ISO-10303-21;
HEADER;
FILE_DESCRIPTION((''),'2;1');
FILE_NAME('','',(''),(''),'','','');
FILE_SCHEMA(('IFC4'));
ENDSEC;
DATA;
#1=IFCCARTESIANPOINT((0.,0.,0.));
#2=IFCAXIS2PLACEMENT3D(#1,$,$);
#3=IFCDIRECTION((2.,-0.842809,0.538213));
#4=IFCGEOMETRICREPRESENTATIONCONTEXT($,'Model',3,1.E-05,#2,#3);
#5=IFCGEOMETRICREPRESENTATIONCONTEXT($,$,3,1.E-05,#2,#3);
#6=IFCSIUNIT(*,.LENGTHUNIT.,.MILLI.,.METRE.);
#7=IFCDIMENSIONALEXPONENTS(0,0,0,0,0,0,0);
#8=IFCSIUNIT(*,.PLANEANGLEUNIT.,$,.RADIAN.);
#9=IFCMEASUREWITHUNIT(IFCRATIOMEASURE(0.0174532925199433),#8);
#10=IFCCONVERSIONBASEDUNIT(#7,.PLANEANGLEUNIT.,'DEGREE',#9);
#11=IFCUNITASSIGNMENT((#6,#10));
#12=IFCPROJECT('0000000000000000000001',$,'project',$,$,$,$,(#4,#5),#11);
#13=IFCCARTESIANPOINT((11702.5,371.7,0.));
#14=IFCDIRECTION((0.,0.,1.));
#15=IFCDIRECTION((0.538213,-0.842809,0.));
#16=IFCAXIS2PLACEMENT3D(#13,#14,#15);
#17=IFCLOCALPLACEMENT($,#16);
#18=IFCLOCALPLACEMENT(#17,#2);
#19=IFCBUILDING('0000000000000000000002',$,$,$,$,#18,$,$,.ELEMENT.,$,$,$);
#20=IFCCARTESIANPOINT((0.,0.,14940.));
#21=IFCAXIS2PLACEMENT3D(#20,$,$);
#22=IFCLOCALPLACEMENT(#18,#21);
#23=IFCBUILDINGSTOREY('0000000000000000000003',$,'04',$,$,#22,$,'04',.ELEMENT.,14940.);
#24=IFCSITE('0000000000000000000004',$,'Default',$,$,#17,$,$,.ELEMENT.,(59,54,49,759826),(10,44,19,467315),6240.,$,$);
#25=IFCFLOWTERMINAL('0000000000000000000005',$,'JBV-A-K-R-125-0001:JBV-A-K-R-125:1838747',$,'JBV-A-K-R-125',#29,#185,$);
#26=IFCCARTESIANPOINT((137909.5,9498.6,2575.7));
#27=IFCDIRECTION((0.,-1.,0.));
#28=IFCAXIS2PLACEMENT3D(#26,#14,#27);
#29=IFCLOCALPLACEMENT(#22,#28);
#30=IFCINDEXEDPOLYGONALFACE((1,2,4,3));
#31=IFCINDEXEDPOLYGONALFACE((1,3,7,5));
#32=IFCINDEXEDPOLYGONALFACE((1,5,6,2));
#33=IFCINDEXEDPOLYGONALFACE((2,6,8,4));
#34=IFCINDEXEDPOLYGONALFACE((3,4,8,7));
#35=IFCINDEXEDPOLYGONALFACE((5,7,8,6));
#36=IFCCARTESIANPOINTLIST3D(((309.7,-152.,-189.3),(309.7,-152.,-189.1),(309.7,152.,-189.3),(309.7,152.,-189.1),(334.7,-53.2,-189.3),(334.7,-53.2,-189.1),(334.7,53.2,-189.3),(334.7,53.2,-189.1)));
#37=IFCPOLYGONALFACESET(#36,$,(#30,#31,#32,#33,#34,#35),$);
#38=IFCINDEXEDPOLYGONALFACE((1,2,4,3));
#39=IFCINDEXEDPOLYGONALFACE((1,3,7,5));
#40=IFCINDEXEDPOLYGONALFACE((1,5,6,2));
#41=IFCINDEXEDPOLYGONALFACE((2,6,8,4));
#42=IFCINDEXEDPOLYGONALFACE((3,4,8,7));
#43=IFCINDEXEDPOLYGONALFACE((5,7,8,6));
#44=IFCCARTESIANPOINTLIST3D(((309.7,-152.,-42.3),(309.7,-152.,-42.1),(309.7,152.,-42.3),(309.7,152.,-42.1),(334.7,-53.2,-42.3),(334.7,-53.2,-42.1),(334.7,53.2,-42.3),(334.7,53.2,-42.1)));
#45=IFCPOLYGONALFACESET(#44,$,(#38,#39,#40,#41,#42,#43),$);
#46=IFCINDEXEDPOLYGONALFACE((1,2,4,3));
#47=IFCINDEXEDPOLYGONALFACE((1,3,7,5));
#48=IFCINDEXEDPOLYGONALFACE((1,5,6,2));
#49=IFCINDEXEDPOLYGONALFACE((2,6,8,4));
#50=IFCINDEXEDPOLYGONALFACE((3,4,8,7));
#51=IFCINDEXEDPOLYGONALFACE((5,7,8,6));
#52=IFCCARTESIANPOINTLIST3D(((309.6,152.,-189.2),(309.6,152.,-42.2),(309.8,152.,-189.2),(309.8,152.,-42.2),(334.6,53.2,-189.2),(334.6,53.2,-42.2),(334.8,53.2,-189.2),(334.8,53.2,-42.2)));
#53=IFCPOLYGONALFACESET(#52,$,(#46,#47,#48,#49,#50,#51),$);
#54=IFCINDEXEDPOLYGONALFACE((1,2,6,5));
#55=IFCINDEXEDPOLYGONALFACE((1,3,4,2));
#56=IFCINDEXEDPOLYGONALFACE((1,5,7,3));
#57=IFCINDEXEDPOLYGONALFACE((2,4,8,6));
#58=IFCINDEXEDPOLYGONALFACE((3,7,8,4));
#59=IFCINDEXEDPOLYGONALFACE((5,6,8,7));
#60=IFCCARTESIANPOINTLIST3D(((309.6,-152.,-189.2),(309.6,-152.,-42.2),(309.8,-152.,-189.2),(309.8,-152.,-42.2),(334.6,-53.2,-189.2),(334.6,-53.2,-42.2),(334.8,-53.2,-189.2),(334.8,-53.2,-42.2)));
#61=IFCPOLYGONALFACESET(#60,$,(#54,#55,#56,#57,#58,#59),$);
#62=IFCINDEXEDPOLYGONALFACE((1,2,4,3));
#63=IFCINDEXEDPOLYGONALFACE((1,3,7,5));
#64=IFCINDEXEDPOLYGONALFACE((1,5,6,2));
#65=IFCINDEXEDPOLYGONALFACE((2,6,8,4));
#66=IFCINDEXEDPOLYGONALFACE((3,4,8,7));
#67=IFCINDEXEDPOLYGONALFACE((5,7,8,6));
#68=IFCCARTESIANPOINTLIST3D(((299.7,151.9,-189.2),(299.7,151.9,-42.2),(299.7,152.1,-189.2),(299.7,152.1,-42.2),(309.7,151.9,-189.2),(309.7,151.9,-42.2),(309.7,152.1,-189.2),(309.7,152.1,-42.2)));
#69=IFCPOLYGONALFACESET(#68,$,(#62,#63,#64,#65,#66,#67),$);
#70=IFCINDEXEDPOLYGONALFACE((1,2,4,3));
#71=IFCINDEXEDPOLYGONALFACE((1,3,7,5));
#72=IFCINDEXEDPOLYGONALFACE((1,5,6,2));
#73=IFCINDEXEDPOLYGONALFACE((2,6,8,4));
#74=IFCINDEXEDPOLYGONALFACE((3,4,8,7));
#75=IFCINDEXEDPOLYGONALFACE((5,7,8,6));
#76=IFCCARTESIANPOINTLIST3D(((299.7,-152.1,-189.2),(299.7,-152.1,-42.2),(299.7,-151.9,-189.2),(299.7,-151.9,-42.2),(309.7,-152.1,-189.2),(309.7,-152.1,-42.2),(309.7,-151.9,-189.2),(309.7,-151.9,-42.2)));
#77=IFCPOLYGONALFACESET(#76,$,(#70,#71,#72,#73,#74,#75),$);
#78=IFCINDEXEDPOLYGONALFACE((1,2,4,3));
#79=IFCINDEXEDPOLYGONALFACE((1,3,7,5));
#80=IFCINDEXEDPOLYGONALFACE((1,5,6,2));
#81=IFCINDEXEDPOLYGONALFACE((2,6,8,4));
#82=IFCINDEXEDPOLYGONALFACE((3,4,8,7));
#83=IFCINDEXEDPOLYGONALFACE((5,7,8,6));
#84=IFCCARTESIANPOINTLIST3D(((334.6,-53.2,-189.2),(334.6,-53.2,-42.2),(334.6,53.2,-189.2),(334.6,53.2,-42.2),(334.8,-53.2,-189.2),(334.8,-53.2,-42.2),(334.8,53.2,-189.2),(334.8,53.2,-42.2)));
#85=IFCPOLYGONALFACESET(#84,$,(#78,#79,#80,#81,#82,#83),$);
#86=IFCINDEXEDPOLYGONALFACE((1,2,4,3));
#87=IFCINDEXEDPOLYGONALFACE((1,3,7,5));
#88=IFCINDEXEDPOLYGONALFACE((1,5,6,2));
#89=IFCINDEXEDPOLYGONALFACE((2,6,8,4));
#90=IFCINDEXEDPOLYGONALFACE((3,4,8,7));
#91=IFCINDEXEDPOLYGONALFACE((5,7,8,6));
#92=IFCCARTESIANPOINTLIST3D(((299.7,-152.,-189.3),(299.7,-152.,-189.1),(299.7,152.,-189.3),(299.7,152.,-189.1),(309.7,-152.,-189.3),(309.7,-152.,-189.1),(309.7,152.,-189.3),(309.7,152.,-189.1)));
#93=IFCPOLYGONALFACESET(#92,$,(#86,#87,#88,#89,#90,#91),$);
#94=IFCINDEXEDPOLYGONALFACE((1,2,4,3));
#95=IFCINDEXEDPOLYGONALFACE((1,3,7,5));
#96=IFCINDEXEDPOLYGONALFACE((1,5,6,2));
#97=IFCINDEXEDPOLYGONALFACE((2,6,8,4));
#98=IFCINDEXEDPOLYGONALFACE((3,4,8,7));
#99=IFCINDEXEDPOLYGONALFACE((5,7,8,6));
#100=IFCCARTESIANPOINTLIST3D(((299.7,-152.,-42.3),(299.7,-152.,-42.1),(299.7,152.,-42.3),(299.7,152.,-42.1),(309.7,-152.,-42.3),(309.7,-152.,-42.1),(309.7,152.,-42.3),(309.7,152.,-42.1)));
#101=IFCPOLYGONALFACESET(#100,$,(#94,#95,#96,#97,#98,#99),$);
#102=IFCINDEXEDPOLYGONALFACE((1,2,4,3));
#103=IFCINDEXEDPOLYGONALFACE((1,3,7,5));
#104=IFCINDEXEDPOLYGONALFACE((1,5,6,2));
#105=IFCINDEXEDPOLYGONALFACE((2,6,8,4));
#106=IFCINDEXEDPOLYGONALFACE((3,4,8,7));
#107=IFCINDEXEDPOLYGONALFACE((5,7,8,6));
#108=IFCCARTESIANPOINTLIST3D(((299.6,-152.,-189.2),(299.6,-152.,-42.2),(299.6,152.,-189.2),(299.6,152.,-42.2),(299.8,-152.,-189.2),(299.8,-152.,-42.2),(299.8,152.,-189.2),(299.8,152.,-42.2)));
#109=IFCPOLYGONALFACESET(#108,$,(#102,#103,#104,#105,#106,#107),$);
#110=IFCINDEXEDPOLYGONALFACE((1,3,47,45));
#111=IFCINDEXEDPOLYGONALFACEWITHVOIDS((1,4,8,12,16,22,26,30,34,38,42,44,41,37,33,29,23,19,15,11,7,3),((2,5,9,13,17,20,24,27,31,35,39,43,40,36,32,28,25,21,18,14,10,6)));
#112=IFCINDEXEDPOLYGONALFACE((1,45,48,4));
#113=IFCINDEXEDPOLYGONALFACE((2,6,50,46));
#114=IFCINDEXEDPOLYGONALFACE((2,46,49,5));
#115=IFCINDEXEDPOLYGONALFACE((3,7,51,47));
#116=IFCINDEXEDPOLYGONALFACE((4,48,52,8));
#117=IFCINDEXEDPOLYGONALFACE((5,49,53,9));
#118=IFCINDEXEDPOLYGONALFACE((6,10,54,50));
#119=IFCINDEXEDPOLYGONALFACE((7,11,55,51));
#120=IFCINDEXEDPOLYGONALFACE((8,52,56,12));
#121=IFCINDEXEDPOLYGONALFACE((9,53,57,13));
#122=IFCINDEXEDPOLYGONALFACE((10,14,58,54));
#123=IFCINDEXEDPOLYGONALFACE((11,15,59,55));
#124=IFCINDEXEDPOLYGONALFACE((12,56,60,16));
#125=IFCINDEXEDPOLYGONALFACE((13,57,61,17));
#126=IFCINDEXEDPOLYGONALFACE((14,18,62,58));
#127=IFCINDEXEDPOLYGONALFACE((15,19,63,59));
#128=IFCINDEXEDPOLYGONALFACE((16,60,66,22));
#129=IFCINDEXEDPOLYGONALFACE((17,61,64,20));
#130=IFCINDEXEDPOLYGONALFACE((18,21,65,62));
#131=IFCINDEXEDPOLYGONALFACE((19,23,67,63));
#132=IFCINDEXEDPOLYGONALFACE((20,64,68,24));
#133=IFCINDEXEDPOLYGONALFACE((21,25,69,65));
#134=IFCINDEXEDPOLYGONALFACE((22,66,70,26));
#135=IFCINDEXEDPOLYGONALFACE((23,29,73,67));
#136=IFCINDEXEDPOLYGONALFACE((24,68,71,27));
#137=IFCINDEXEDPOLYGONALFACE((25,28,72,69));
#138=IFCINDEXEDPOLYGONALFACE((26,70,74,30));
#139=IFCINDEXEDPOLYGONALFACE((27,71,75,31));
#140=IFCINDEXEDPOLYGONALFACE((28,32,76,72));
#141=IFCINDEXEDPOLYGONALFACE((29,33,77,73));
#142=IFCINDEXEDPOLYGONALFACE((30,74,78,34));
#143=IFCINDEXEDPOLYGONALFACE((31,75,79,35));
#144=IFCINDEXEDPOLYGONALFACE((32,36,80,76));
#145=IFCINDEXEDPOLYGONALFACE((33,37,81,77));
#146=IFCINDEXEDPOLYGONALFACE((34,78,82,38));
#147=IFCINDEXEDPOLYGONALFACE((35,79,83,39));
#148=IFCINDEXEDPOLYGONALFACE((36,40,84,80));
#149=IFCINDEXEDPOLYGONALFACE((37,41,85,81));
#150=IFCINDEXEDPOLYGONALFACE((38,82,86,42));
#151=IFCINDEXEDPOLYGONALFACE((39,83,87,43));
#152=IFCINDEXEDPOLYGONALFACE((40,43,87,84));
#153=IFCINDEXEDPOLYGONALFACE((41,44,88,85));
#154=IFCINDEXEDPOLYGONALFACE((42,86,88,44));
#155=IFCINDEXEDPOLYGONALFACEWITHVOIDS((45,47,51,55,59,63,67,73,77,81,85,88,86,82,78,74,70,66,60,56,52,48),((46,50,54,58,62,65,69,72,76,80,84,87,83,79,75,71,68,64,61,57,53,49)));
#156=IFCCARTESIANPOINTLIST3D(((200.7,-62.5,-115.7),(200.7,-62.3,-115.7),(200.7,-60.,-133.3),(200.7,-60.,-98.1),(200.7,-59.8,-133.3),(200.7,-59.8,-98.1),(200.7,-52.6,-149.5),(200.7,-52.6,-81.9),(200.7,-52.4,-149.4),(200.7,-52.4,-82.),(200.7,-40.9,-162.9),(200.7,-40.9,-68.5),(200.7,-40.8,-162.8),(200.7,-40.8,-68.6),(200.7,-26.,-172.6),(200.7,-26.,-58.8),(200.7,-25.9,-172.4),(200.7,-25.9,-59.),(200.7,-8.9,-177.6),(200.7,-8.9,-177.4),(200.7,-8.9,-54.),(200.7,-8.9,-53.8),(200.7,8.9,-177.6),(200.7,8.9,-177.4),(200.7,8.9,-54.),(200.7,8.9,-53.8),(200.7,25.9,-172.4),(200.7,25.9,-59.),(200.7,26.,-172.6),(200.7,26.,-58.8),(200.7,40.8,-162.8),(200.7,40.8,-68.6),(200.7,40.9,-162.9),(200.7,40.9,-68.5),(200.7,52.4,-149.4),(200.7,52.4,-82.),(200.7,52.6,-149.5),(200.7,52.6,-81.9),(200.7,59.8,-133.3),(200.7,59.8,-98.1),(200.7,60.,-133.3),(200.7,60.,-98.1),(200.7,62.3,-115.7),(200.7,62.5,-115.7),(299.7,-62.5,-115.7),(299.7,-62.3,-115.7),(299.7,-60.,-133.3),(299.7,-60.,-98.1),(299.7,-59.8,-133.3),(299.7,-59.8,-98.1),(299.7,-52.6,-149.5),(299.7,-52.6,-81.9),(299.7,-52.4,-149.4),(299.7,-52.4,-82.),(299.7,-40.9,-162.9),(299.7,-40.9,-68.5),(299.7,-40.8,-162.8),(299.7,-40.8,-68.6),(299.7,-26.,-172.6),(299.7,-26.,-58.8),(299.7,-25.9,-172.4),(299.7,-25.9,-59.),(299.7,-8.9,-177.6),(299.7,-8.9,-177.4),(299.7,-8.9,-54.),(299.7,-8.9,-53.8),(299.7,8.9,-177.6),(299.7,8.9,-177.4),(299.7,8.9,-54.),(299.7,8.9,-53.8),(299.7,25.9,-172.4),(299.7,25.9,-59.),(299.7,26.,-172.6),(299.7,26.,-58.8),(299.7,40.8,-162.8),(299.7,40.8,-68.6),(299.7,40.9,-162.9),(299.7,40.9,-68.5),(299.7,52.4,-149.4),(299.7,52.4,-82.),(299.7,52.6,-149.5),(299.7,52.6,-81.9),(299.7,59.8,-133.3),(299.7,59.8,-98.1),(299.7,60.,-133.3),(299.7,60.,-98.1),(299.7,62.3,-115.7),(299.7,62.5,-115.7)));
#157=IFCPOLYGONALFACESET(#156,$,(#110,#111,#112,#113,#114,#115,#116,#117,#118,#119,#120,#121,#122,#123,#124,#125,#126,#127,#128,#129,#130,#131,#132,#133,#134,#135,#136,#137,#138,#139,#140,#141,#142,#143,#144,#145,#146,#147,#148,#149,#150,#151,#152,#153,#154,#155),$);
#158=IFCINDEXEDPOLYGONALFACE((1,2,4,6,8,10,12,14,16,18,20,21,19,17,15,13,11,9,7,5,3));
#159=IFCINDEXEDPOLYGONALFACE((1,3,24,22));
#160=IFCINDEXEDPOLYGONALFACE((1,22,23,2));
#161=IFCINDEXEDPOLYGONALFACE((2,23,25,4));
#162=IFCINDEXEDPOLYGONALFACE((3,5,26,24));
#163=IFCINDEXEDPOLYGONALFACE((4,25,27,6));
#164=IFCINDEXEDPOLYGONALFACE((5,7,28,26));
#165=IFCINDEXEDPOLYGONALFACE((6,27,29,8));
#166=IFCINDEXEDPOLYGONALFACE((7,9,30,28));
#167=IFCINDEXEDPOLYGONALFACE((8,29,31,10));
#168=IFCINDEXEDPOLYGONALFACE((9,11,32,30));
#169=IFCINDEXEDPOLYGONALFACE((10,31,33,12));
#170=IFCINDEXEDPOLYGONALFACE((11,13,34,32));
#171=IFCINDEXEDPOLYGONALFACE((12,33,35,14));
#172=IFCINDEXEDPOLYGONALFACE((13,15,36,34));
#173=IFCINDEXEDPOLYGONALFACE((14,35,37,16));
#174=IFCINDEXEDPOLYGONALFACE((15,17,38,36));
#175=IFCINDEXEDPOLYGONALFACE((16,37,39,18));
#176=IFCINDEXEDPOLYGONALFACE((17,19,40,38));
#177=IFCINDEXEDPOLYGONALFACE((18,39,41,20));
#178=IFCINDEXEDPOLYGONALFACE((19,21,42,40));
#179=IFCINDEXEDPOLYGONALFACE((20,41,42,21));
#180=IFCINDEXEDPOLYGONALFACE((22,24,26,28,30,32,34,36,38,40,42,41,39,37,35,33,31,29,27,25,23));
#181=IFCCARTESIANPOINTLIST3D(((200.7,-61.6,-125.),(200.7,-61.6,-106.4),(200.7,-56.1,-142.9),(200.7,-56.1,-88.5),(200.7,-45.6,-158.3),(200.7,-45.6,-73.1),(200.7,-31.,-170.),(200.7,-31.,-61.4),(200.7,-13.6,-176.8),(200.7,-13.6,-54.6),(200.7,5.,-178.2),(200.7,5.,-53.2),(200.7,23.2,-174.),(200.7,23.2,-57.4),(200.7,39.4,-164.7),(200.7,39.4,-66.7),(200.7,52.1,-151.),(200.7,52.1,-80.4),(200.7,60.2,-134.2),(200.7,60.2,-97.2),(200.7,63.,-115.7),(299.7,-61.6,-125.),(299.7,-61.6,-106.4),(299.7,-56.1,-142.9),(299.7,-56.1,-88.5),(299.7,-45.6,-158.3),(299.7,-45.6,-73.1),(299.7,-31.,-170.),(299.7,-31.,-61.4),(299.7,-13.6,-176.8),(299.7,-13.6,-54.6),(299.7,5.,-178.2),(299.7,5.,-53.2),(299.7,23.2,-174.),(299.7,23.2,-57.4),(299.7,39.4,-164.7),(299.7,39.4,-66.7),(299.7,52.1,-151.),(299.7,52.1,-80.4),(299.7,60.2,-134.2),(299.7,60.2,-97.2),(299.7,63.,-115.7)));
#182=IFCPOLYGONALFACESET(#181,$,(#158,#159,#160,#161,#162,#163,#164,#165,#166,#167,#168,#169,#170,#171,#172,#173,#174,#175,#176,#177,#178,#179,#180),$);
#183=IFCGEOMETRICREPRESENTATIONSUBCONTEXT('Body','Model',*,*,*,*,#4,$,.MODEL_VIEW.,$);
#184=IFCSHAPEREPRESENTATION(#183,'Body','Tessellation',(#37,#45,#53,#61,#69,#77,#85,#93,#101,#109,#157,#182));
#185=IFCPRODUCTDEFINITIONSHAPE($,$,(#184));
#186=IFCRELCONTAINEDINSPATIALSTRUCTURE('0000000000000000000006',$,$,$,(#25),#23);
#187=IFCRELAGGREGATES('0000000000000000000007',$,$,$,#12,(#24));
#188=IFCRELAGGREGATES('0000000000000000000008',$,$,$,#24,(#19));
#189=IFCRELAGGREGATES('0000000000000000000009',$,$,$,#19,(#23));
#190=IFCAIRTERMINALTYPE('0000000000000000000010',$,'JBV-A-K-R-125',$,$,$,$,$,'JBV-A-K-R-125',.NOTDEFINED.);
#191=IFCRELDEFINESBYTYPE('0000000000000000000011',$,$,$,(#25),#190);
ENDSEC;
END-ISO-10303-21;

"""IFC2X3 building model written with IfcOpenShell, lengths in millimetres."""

from ifc_helpers import new_model, entity, si_unit, converted_unit, direction, frame, frame_2d, origin, origin_2d_with_axis, place, context, subcontext, project, spatial, polyline, circle_curve, parameter, trimmed, segment, composite_curve, rectangle, circle, outline, extrude, source, transform, mapped, type_object, type_shapes, element, save


model = new_model("IFC2X3")

# Units and contexts
model_context = context("Model", 3, precision=1e-05, world=origin(), true_north=direction((2.0, -0.842809, 0.538213)))
context_of_model = context(None, 3, precision=1e-05, world=origin(), true_north=direction((2.0, -0.842809, 0.538213)))
body_context = subcontext(model_context, "Body", "Model", "MODEL_VIEW")
ifc_project = project(units=[si_unit("LENGTHUNIT", "METRE", prefix="MILLI"), converted_unit("PLANEANGLEUNIT", "DEGREE", entity("IfcRatioMeasure", 0.0174532925199433), si_unit("PLANEANGLEUNIT", "RADIAN"), dimensions=[0, 0, 0, 0, 0, 0, 0])], contexts=[model_context, context_of_model])

# Site, building, storey
site_placement = place(None, frame((11702.5, 371.7, 0.0), z_axis=(0.0, 0.0, 1.0), x_axis=(0.538213, -0.842809, 0.0)))
site = spatial("IfcSite", under=ifc_project, at=site_placement, Name="Default", CompositionType="ELEMENT", RefLatitude=(59, 54, 49, 759826), RefLongitude=(10, 44, 19, 467315), RefElevation=6240.0)
building_placement = place(site_placement, origin())
building = spatial("IfcBuilding", under=site, at=building_placement, CompositionType="ELEMENT")
storey_placement = place(building_placement, frame((0.0, 0.0, 14940.0)))
storey = spatial("IfcBuildingStorey", under=building, at=storey_placement, Name="04", LongName="04", CompositionType="ELEMENT", Elevation=14940.0)

# Flow terminal
air_terminal_type_1 = type_object("IfcAirTerminalType", Name="JBV-A-K-R-125", ElementType="JBV-A-K-R-125", PredefinedType="NOTDEFINED")
shared_shape_1 = source(origin(), body_context, "Body", "SweptSolid", [
    extrude(outline(polyline([(-152.0, -12.5), (152.0, -12.5), (53.2, 12.5), (-53.2, 12.5), (-152.0, -12.5)])), frame((322.2, 0.0, -189.3), z_axis=(0.0, 0.0, 1.0), x_axis=(0.0, -1.0, 0.0)), (0.0, 0.0, 1.0), 0.2),
    extrude(outline(polyline([(-152.0, -12.5), (152.0, -12.5), (53.2, 12.5), (-53.2, 12.5), (-152.0, -12.5)])), frame((322.2, 0.0, -42.3), z_axis=(0.0, 0.0, 1.0), x_axis=(0.0, -1.0, 0.0)), (0.0, 0.0, 1.0), 0.2),
    extrude(rectangle(XDim=0.2, YDim=101.9, at=frame_2d((0.0, 0.0), x_axis=(1.0, 0.0))), frame((322.2, 102.6, -189.2), z_axis=(0.0, 0.0, 1.0), x_axis=(0.969446, 0.245305, 0.0)), (0.0, 0.0, 1.0), 147.0),
    extrude(rectangle(XDim=0.2, YDim=101.9, at=frame_2d((0.0, 0.0), x_axis=(1.0, 0.0))), frame((322.2, -102.6, -189.2), z_axis=(0.0, 0.0, 1.0), x_axis=(-0.969446, 0.245305, 0.0)), (0.0, 0.0, 1.0), 147.0),
    extrude(rectangle(XDim=0.2, YDim=10.0, at=frame_2d((0.0, 0.0), x_axis=(1.0, 0.0))), frame((304.7, 152.0, -189.2), z_axis=(0.0, 0.0, 1.0), x_axis=(0.0, 1.0, 0.0)), (0.0, 0.0, 1.0), 147.0),
    extrude(rectangle(XDim=0.2, YDim=10.0, at=frame_2d((0.0, 0.0), x_axis=(1.0, 0.0))), frame((304.7, -152.0, -189.2), z_axis=(0.0, 0.0, 1.0), x_axis=(0.0, 1.0, 0.0)), (0.0, 0.0, 1.0), 147.0),
    extrude(rectangle(XDim=0.2, YDim=106.4, at=frame_2d((0.0, 0.0), x_axis=(1.0, 0.0))), frame((334.7, 0.0, -189.2)), (0.0, 0.0, 1.0), 147.0),
    extrude(rectangle(XDim=304.0, YDim=10.0, at=frame_2d((0.0, 0.0), x_axis=(1.0, 0.0))), frame((304.7, 0.0, -189.3), z_axis=(0.0, 0.0, 1.0), x_axis=(0.0, -1.0, 0.0)), (0.0, 0.0, 1.0), 0.2),
    extrude(rectangle(XDim=304.0, YDim=10.0, at=frame_2d((0.0, 0.0), x_axis=(1.0, 0.0))), frame((304.7, 0.0, -42.3), z_axis=(0.0, 0.0, 1.0), x_axis=(0.0, -1.0, 0.0)), (0.0, 0.0, 1.0), 0.2),
    extrude(rectangle(XDim=0.2, YDim=304.0, at=frame_2d((0.0, 0.0), x_axis=(1.0, 0.0))), frame((299.7, 0.0, -189.2)), (0.0, 0.0, 1.0), 147.0),
    extrude(outline(composite_curve([segment(trimmed(circle_curve(origin_2d_with_axis(), 62.5), [parameter(0.0)], [parameter(180.0)], True, "PARAMETER"), True, "CONTINUOUS"), segment(trimmed(circle_curve(origin_2d_with_axis(), 62.5), [parameter(180.0)], [parameter(360.0)], True, "PARAMETER"), True, "CONTINUOUS")], self_intersect=False), holes=[composite_curve([segment(trimmed(circle_curve(origin_2d_with_axis(), 62.3), [parameter(180.0)], [parameter(360.0)], True, "PARAMETER"), False, "CONTINUOUS"), segment(trimmed(circle_curve(origin_2d_with_axis(), 62.3), [parameter(0.0)], [parameter(180.0)], True, "PARAMETER"), False, "CONTINUOUS")], self_intersect=False)]), frame((200.7, 0.0, -115.7), z_axis=(1.0, 0.0, 0.0), x_axis=(0.0, 1.0, 0.0)), (0.0, 0.0, 1.0), 99.0),
    extrude(circle(Radius=62.6, at=frame_2d((0.0, 0.0), x_axis=(1.0, 0.0))), frame((200.7, 0.3, -115.7), z_axis=(1.0, 0.0, 0.0), x_axis=(0.0, 1.0, 0.0)), (0.0, 0.0, 1.0), 99.0),
])
type_shapes(air_terminal_type_1, [shared_shape_1])
for number, where, z_axis, x_axis, name in (
    (1, (137909.5, 9498.6, 2575.7), (0.0, 0.0, 1.0), (0.0, -1.0, 0.0), "JBV-A-K-R-125-0001:JBV-A-K-R-125:1838747"),
):
    element("IfcFlowTerminal", number, at=place(storey_placement, frame(where, z_axis=z_axis, x_axis=x_axis)), inside=storey, type_object=air_terminal_type_1, Name=name, ObjectType="JBV-A-K-R-125", context=body_context, shape_type="MappedRepresentation", body=[
        mapped(shared_shape_1, transform((0.0, 0.0, 0.0), scale=1.0)),
    ])

save(model, "model.ifc")
